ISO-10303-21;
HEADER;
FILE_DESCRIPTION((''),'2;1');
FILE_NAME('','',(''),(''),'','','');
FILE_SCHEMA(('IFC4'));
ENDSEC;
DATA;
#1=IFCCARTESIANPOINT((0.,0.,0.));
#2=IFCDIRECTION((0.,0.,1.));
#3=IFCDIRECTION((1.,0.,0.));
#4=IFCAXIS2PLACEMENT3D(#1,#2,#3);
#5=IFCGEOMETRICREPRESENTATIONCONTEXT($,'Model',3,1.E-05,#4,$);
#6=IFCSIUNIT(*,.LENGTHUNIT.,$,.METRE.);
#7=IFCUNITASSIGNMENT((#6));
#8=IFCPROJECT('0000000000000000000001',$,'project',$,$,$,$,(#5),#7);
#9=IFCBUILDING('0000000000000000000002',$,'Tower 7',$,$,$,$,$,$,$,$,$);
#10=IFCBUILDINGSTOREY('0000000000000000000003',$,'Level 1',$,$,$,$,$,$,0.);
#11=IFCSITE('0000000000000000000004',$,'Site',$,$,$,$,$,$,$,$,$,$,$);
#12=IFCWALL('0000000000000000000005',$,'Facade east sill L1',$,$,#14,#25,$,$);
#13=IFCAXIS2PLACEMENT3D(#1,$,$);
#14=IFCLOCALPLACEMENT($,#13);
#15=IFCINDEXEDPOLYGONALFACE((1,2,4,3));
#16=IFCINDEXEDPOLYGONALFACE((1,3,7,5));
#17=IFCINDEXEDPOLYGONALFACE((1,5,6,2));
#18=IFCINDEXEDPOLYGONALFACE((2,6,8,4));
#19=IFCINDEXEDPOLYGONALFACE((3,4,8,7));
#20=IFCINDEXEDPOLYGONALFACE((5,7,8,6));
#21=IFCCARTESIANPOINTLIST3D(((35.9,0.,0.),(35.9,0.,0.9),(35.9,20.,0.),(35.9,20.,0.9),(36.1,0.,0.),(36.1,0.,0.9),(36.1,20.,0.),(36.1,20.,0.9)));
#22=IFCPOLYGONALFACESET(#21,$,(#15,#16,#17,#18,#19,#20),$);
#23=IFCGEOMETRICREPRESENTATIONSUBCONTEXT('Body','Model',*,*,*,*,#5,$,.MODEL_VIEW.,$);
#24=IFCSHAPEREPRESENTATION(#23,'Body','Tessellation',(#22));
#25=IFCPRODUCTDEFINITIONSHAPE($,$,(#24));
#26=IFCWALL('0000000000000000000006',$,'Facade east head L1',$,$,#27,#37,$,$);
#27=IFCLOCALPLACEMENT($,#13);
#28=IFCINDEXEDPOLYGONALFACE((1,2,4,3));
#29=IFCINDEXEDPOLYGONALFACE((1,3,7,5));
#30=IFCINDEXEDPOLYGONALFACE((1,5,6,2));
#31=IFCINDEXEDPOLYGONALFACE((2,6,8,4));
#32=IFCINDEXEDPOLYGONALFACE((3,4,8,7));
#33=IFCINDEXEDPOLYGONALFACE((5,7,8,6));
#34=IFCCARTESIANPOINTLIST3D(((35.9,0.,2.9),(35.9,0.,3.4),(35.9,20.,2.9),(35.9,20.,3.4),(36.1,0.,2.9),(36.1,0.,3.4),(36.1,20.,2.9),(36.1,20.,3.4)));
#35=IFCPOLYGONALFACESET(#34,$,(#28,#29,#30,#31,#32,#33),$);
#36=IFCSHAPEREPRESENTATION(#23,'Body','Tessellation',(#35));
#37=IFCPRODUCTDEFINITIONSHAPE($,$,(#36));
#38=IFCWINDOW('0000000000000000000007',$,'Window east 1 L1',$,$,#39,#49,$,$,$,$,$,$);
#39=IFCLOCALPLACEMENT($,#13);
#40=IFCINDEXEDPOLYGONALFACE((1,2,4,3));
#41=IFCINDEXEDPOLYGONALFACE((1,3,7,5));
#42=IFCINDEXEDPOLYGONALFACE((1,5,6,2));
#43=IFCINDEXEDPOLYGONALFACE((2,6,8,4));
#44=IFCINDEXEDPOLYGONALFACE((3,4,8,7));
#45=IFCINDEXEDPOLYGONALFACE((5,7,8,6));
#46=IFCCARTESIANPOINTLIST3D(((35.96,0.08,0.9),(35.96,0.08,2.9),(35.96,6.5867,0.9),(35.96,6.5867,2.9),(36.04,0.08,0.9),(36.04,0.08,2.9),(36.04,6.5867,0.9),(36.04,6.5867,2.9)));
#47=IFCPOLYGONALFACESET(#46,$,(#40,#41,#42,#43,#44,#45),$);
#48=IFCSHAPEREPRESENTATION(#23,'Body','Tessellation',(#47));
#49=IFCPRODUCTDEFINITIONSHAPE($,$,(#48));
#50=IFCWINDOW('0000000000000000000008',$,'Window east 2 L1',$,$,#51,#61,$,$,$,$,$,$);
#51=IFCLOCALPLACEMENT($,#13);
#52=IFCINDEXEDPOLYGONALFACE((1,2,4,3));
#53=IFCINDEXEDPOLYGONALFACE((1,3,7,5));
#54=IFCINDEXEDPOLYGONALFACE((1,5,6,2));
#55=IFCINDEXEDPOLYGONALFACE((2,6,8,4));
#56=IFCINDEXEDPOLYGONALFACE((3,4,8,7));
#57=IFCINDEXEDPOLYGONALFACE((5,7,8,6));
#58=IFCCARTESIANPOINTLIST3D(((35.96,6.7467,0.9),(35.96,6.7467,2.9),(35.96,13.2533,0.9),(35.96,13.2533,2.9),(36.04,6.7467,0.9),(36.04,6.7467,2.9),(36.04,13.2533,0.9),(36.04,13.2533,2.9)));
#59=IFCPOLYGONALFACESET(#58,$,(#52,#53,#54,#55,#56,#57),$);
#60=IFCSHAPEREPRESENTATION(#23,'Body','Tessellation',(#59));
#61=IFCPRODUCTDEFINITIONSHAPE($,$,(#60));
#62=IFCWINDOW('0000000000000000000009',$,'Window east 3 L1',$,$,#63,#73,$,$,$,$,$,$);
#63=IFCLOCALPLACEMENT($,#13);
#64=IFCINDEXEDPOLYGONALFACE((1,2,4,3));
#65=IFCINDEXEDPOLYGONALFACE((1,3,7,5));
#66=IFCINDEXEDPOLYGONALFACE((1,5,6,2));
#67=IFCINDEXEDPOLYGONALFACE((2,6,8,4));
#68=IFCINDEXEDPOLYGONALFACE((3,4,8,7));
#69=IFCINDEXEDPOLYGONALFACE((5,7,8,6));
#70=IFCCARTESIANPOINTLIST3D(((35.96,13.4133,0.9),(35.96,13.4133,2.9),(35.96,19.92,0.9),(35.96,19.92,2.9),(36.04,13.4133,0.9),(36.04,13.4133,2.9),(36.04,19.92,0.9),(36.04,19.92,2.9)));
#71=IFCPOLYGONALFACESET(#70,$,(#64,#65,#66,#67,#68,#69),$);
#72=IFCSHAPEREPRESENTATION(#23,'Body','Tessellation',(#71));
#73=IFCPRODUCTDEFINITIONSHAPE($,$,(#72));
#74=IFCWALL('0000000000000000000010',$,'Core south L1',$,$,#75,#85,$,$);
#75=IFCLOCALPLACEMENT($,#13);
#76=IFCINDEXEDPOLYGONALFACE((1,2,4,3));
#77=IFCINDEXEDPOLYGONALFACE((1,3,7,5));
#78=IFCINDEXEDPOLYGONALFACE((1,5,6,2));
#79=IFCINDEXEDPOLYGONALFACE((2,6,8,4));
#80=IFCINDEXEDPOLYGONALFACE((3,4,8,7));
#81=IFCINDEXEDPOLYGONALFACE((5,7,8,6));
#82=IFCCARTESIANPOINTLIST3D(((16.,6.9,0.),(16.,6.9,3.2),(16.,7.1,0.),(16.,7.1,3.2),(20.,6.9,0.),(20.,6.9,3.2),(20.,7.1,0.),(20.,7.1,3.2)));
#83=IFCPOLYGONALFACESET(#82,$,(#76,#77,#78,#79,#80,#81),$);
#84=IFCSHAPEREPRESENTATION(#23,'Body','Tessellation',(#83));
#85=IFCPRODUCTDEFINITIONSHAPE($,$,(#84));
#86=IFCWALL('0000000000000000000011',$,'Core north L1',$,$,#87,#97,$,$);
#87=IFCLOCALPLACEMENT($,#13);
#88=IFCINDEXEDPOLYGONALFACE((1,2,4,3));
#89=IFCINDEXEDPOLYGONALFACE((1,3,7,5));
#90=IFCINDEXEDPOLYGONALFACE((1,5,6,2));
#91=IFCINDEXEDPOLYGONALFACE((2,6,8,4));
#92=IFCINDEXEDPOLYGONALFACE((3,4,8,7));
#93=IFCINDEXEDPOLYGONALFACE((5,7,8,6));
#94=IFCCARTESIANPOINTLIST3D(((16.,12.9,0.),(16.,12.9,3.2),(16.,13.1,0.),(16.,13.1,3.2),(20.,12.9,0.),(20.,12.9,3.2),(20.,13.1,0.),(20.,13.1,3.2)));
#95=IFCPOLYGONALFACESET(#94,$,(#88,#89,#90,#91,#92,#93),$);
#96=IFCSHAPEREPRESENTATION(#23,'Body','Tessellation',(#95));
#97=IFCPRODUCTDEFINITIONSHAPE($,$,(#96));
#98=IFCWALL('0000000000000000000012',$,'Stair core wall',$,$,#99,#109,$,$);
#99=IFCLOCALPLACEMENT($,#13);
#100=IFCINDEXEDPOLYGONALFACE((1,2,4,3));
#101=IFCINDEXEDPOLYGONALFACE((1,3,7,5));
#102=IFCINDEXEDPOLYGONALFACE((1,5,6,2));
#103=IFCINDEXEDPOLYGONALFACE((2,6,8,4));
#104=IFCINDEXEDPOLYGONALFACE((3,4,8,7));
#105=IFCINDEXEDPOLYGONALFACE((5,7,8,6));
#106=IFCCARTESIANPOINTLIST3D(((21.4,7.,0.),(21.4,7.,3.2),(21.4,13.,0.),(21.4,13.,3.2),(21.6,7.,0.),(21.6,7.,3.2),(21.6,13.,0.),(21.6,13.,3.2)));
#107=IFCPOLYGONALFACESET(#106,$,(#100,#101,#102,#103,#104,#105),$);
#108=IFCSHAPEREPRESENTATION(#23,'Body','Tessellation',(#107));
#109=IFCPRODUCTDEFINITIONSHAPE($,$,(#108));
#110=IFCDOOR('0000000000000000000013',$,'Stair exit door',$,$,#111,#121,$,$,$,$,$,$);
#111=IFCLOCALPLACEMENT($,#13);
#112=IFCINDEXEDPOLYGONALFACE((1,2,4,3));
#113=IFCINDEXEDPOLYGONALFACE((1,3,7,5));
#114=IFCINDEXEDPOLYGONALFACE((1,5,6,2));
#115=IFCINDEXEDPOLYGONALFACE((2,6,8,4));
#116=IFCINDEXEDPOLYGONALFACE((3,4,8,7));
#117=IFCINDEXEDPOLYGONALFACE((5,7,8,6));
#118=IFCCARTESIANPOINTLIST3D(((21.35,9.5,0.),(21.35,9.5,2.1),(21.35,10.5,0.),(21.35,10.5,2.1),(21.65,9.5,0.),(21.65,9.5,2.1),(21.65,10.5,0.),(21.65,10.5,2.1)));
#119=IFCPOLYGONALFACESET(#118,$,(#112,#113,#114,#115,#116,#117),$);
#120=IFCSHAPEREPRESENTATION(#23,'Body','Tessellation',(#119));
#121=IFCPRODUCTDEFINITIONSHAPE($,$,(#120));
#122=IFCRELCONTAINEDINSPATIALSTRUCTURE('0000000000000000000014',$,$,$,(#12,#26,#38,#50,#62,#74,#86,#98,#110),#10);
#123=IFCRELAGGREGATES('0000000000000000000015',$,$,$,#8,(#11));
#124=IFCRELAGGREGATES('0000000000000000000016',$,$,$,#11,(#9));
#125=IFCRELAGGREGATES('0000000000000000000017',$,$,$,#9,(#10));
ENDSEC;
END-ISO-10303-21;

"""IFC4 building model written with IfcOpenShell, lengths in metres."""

from ifc_helpers import new_model, si_unit, frame, origin, origin_with_axes, origin_2d, place, context, subcontext, project, spatial, rectangle, extrude, element, save


model = new_model("IFC4")

# Units and contexts
model_context = context("Model", 3, precision=1e-05, world=origin_with_axes())
body_context = subcontext(model_context, "Body", "Model", "MODEL_VIEW")
ifc_project = project(units=[si_unit("LENGTHUNIT", "METRE")], contexts=[model_context])

# Site, building, storey
site = spatial("IfcSite", under=ifc_project, Name="Site")
building = spatial("IfcBuilding", under=site, Name="Tower 7")
storey = spatial("IfcBuildingStorey", under=building, Name="Level 1", Elevation=0.0)

# Walls
wall_1_placement = place(None, frame((36.0, 10.0, 0.0), z_axis=(0.0, 0.0, 1.0), x_axis=(1.0, 0.0, 0.0)))
element("IfcWall", 1, at=wall_1_placement, inside=storey, Name="Facade east sill L1", context=body_context, shape_type="SweptSolid", body=[
    extrude(rectangle(XDim=0.2, YDim=20.0, at=origin_2d()), origin(), (0.0, 0.0, 1.0), 0.9),
])
wall_2_placement = place(None, frame((36.0, 10.0, 2.9), z_axis=(0.0, 0.0, 1.0), x_axis=(1.0, 0.0, 0.0)))
element("IfcWall", 2, at=wall_2_placement, inside=storey, Name="Facade east head L1", context=body_context, shape_type="SweptSolid", body=[
    extrude(rectangle(XDim=0.2, YDim=20.0, at=origin_2d()), origin(), (0.0, 0.0, 1.0), 0.5),
])

# Windows
for number, where, z_axis, x_axis, name in (
    (3, (36.0, 3.3333, 0.9), (0.0, 0.0, 1.0), (1.0, 0.0, 0.0), "Window east 1 L1"),
    (4, (36.0, 10.0, 0.9), (0.0, 0.0, 1.0), (1.0, 0.0, 0.0), "Window east 2 L1"),
):
    element("IfcWindow", number, at=place(None, frame(where, z_axis=z_axis, x_axis=x_axis)), inside=storey, Name=name, context=body_context, shape_type="SweptSolid", body=[
        extrude(rectangle(XDim=0.08, YDim=6.5067, at=origin_2d()), origin(), (0.0, 0.0, 1.0), 2.0),
    ])
window_placement = place(None, frame((36.0, 16.6667, 0.9), z_axis=(0.0, 0.0, 1.0), x_axis=(1.0, 0.0, 0.0)))
element("IfcWindow", 5, at=window_placement, inside=storey, Name="Window east 3 L1", context=body_context, shape_type="SweptSolid", body=[
    extrude(rectangle(XDim=0.08, YDim=6.5067, at=origin_2d()), origin(), (0.0, 0.0, 1.0), 2.0),
])

# Walls
for number, where, z_axis, x_axis, name in (
    (6, (18.0, 7.0, 0.0), (0.0, 0.0, 1.0), (1.0, 0.0, 0.0), "Core south L1"),
    (7, (18.0, 13.0, 0.0), (0.0, 0.0, 1.0), (1.0, 0.0, 0.0), "Core north L1"),
):
    element("IfcWall", number, at=place(None, frame(where, z_axis=z_axis, x_axis=x_axis)), inside=storey, Name=name, context=body_context, shape_type="SweptSolid", body=[
        extrude(rectangle(XDim=4.0, YDim=0.2, at=origin_2d()), origin(), (0.0, 0.0, 1.0), 3.2),
    ])
wall_3_placement = place(None, frame((21.5, 10.0, 0.0), z_axis=(0.0, 0.0, 1.0), x_axis=(1.0, 0.0, 0.0)))
element("IfcWall", 8, at=wall_3_placement, inside=storey, Name="Stair core wall", context=body_context, shape_type="SweptSolid", body=[
    extrude(rectangle(XDim=0.2, YDim=6.0, at=origin_2d()), origin(), (0.0, 0.0, 1.0), 3.2),
])

# Door
door_placement = place(None, frame((21.5, 10.0, 0.0), z_axis=(0.0, 0.0, 1.0), x_axis=(1.0, 0.0, 0.0)))
element("IfcDoor", 9, at=door_placement, inside=storey, Name="Stair exit door", context=body_context, shape_type="SweptSolid", body=[
    extrude(rectangle(XDim=0.3, YDim=1.0, at=origin_2d()), origin(), (0.0, 0.0, 1.0), 2.1),
])

save(model, "model.ifc")
